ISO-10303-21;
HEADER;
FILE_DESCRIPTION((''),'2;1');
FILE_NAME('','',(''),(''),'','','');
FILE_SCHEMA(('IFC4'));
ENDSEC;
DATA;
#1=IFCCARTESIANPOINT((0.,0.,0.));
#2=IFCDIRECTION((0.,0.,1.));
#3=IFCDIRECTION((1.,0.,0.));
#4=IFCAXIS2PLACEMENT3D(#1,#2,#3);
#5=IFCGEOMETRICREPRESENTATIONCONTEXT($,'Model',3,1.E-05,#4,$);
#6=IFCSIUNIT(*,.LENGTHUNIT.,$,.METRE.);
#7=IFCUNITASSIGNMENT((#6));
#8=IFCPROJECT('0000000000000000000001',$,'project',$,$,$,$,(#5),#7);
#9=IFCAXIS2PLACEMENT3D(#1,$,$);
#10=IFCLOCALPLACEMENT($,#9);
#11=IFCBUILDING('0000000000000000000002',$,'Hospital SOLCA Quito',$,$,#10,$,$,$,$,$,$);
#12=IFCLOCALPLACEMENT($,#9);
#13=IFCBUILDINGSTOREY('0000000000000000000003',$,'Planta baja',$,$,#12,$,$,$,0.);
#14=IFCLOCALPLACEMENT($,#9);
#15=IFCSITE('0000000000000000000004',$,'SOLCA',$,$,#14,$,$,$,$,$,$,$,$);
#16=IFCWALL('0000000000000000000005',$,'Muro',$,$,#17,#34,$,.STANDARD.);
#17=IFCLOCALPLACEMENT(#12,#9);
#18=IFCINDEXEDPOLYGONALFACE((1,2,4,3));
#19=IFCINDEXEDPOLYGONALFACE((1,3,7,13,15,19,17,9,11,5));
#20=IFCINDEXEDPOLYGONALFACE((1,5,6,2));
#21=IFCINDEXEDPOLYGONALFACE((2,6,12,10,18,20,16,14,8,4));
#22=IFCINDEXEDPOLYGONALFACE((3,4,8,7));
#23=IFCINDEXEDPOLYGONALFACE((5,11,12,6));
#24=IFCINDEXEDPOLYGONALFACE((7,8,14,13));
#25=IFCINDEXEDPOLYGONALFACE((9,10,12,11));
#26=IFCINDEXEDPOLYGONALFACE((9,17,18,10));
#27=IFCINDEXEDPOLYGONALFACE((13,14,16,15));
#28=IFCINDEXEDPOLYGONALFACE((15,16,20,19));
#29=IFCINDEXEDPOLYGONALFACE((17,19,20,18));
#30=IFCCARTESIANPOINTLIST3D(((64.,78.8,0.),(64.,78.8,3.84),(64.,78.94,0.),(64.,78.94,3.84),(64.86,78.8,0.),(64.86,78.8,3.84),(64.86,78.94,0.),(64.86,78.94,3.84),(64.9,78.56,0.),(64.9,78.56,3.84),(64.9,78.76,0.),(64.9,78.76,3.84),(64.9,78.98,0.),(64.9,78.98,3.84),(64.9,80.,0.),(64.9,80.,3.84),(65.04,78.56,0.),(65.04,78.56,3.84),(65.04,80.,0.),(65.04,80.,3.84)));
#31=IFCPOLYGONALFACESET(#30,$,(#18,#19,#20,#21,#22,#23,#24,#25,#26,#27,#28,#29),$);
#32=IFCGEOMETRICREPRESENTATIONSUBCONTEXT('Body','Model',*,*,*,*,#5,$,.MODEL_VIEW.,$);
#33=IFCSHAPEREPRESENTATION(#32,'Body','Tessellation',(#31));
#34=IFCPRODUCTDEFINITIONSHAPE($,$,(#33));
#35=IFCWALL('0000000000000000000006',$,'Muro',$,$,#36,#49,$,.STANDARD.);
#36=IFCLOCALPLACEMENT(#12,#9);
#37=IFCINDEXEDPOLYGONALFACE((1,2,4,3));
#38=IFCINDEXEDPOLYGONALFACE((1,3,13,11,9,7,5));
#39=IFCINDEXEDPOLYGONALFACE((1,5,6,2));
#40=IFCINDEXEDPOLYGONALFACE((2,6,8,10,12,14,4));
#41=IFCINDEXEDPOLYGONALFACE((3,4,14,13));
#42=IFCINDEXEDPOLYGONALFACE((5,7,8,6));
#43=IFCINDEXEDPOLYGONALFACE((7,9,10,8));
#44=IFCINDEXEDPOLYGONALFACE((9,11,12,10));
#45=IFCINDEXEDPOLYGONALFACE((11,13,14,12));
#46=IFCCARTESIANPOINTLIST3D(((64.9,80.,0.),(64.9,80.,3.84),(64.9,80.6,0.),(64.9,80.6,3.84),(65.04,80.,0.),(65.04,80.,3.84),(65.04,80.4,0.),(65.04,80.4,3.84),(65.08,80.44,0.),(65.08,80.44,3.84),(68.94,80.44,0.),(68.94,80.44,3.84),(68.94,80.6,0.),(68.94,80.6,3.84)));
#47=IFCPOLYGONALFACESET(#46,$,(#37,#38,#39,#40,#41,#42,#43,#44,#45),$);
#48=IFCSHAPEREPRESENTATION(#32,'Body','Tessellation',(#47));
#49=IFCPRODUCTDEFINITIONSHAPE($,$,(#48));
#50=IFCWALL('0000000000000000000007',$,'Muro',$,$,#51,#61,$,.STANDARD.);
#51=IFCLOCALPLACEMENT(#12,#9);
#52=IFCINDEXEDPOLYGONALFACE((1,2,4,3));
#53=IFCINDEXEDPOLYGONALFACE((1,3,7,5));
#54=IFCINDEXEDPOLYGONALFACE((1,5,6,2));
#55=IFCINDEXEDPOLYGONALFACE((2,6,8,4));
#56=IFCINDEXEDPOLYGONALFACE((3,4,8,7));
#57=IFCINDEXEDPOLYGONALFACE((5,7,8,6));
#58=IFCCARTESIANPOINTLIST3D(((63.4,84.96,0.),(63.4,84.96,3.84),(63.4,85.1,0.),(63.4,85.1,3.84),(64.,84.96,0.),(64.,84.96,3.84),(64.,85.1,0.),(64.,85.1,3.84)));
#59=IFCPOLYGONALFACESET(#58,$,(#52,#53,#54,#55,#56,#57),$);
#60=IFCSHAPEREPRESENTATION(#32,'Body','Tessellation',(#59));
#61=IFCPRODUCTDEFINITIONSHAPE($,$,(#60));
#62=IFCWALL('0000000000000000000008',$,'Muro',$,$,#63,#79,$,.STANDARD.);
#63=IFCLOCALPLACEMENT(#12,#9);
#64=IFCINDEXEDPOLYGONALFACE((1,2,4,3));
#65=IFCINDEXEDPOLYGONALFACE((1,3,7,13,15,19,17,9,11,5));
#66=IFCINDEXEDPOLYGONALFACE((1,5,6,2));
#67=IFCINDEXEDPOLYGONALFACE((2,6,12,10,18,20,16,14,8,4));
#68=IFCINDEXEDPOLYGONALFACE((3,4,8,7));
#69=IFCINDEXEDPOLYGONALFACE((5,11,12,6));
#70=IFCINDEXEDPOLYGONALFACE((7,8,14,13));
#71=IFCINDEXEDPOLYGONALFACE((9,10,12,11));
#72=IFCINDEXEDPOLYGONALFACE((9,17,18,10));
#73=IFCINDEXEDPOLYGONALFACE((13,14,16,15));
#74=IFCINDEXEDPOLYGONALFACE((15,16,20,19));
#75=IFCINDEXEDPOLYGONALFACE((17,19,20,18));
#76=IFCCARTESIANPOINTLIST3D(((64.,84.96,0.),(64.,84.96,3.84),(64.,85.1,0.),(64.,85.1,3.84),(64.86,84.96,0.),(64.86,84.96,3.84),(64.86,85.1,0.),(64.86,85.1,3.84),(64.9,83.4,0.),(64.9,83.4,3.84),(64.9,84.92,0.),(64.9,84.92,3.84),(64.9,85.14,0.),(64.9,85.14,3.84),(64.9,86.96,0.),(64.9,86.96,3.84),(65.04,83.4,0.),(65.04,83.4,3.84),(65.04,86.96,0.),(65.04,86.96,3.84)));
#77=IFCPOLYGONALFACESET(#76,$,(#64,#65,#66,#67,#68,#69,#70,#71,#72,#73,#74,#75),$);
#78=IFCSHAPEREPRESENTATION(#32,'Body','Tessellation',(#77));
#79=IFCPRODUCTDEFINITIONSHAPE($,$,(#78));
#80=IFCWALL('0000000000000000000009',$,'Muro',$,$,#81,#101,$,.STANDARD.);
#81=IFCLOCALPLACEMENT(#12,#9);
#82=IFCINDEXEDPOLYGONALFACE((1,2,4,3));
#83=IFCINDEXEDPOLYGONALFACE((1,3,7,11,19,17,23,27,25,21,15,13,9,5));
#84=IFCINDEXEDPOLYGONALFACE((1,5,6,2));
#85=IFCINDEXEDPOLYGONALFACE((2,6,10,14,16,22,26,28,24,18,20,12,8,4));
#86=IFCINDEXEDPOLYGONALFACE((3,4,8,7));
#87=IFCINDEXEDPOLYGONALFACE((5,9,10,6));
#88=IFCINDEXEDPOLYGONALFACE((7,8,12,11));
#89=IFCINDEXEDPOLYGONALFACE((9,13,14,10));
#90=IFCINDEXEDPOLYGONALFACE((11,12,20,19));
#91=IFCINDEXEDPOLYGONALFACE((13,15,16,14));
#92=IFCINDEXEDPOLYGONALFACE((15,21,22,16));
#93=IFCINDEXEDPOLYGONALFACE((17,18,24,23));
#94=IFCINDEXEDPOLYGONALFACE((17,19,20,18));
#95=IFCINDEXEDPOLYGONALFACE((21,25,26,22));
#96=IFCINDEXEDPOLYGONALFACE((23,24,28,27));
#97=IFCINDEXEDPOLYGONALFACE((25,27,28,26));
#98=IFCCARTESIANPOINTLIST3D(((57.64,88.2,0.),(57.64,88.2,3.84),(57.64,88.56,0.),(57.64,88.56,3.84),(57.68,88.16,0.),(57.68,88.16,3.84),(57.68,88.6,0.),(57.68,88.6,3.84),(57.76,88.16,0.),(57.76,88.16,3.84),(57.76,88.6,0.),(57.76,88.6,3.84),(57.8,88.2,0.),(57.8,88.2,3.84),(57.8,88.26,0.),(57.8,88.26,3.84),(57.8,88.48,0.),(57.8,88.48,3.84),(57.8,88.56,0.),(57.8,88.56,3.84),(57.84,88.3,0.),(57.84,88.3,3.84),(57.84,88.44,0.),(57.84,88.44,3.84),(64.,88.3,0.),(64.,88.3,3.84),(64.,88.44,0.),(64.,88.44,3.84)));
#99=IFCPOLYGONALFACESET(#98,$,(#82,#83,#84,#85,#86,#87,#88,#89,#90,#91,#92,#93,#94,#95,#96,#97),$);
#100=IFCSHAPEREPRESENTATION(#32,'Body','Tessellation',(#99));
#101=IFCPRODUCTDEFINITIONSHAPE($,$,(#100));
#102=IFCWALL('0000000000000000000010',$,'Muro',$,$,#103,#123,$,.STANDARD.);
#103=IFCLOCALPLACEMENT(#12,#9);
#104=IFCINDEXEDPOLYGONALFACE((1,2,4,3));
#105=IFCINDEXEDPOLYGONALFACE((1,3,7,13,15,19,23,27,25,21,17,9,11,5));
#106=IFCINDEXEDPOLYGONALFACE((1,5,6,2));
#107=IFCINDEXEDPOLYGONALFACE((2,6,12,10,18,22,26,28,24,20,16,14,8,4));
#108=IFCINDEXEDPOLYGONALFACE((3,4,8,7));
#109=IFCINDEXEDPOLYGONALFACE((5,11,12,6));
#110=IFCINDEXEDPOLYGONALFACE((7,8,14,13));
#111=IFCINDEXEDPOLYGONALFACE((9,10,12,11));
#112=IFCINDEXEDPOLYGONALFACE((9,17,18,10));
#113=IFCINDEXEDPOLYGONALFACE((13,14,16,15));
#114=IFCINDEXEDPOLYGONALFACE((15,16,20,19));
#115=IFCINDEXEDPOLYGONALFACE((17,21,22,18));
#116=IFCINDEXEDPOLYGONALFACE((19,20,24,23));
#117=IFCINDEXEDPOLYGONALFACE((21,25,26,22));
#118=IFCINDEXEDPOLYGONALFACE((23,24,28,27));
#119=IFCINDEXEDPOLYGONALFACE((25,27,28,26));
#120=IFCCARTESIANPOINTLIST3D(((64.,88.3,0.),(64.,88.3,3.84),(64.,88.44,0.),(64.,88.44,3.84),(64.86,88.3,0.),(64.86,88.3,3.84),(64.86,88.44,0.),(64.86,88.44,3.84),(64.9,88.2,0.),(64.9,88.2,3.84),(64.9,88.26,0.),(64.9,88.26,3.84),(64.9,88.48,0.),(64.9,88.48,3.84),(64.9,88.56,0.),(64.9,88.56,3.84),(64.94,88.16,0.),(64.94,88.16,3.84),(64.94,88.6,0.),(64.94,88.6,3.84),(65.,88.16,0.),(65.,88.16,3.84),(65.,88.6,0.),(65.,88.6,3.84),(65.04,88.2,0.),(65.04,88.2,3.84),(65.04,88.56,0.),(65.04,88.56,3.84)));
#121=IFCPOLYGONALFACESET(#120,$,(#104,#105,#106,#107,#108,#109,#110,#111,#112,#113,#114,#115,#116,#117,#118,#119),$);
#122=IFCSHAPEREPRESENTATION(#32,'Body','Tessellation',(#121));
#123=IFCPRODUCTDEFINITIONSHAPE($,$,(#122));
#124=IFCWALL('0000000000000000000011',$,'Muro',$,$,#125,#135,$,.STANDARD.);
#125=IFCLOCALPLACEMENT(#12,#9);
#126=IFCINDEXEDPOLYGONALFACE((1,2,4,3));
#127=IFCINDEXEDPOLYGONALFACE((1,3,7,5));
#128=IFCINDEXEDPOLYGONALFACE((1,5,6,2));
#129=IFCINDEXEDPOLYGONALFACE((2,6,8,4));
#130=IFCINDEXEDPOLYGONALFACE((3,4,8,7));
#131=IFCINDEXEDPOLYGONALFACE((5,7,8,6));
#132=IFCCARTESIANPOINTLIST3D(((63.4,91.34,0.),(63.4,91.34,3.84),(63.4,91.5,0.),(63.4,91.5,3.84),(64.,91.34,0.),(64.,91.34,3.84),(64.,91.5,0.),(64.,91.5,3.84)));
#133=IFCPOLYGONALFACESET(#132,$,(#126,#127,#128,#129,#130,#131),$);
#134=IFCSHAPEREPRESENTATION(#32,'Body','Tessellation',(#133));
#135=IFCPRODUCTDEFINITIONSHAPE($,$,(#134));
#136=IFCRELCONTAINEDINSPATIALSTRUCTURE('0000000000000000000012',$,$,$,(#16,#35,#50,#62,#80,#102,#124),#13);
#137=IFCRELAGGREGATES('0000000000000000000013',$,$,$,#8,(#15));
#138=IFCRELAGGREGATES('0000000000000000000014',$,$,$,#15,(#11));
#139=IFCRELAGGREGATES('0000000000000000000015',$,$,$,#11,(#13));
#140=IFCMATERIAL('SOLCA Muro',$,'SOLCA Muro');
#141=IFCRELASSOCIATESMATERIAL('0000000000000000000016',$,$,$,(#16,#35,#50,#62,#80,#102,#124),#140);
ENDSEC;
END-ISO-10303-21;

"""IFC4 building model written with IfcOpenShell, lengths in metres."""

from ifc_helpers import new_model, si_unit, origin, origin_with_axes, place, context, subcontext, project, spatial, polyline, outline, extrude, material, element, save


model = new_model("IFC4")

# Units and contexts
model_context = context("Model", 3, precision=1e-05, world=origin_with_axes())
body_context = subcontext(model_context, "Body", "Model", "MODEL_VIEW")
ifc_project = project(units=[si_unit("LENGTHUNIT", "METRE")], contexts=[model_context])

# Site, building, storey
site_placement = place(None, origin())
site = spatial("IfcSite", under=ifc_project, at=site_placement, Name="SOLCA")
building_placement = place(None, origin())
building = spatial("IfcBuilding", under=site, at=building_placement, Name="Hospital SOLCA Quito")
storey_placement = place(None, origin())
storey = spatial("IfcBuildingStorey", under=building, at=storey_placement, Name="Planta baja", Elevation=0.0)

# Walls
ifc_material = material(Name="SOLCA Muro", Category="SOLCA Muro")
wall_1_placement = place(storey_placement, origin_with_axes())
element("IfcWall", 1, at=wall_1_placement, inside=storey, material=ifc_material, Name="Muro", PredefinedType="STANDARD", context=body_context, shape_type="SweptSolid", body=[
    extrude(outline(polyline([(64.9, 78.56), (64.9, 78.76), (64.86, 78.8), (64.0, 78.8), (64.0, 78.94), (64.86, 78.94), (64.9, 78.98), (64.9, 80.0), (65.04, 80.0), (65.04, 78.56), (64.9, 78.56)])), origin_with_axes(), (0.0, 0.0, 1.0), 3.84),
])
wall_2_placement = place(storey_placement, origin_with_axes())
element("IfcWall", 2, at=wall_2_placement, inside=storey, material=ifc_material, Name="Muro", PredefinedType="STANDARD", context=body_context, shape_type="SweptSolid", body=[
    extrude(outline(polyline([(64.9, 80.6), (68.94, 80.6), (68.94, 80.44), (65.08, 80.44), (65.04, 80.4), (65.04, 80.0), (64.9, 80.0), (64.9, 80.6)])), origin_with_axes(), (0.0, 0.0, 1.0), 3.84),
])
wall_3_placement = place(storey_placement, origin_with_axes())
element("IfcWall", 3, at=wall_3_placement, inside=storey, material=ifc_material, Name="Muro", PredefinedType="STANDARD", context=body_context, shape_type="SweptSolid", body=[
    extrude(outline(polyline([(63.4, 84.96), (63.4, 85.1), (64.0, 85.1), (64.0, 84.96), (63.4, 84.96)])), origin_with_axes(), (0.0, 0.0, 1.0), 3.84),
])
wall_4_placement = place(storey_placement, origin_with_axes())
element("IfcWall", 4, at=wall_4_placement, inside=storey, material=ifc_material, Name="Muro", PredefinedType="STANDARD", context=body_context, shape_type="SweptSolid", body=[
    extrude(outline(polyline([(64.9, 85.14), (64.9, 86.96), (65.04, 86.96), (65.04, 83.4), (64.9, 83.4), (64.9, 84.92), (64.86, 84.96), (64.0, 84.96), (64.0, 85.1), (64.86, 85.1), (64.9, 85.14)])), origin_with_axes(), (0.0, 0.0, 1.0), 3.84),
])
wall_5_placement = place(storey_placement, origin_with_axes())
element("IfcWall", 5, at=wall_5_placement, inside=storey, material=ifc_material, Name="Muro", PredefinedType="STANDARD", context=body_context, shape_type="SweptSolid", body=[
    extrude(outline(polyline([(57.8, 88.26), (57.8, 88.2), (57.76, 88.16), (57.68, 88.16), (57.64, 88.2), (57.64, 88.56), (57.68, 88.6), (57.76, 88.6), (57.8, 88.56), (57.8, 88.48), (57.84, 88.44), (64.0, 88.44), (64.0, 88.3), (57.84, 88.3), (57.8, 88.26)])), origin_with_axes(), (0.0, 0.0, 1.0), 3.84),
])
wall_6_placement = place(storey_placement, origin_with_axes())
element("IfcWall", 6, at=wall_6_placement, inside=storey, material=ifc_material, Name="Muro", PredefinedType="STANDARD", context=body_context, shape_type="SweptSolid", body=[
    extrude(outline(polyline([(64.86, 88.44), (64.9, 88.48), (64.9, 88.56), (64.94, 88.6), (65.0, 88.6), (65.04, 88.56), (65.04, 88.2), (65.0, 88.16), (64.94, 88.16), (64.9, 88.2), (64.9, 88.26), (64.86, 88.3), (64.0, 88.3), (64.0, 88.44), (64.86, 88.44)])), origin_with_axes(), (0.0, 0.0, 1.0), 3.84),
])
wall_7_placement = place(storey_placement, origin_with_axes())
element("IfcWall", 7, at=wall_7_placement, inside=storey, material=ifc_material, Name="Muro", PredefinedType="STANDARD", context=body_context, shape_type="SweptSolid", body=[
    extrude(outline(polyline([(63.4, 91.34), (63.4, 91.5), (64.0, 91.5), (64.0, 91.34), (63.4, 91.34)])), origin_with_axes(), (0.0, 0.0, 1.0), 3.84),
])

save(model, "model.ifc")
